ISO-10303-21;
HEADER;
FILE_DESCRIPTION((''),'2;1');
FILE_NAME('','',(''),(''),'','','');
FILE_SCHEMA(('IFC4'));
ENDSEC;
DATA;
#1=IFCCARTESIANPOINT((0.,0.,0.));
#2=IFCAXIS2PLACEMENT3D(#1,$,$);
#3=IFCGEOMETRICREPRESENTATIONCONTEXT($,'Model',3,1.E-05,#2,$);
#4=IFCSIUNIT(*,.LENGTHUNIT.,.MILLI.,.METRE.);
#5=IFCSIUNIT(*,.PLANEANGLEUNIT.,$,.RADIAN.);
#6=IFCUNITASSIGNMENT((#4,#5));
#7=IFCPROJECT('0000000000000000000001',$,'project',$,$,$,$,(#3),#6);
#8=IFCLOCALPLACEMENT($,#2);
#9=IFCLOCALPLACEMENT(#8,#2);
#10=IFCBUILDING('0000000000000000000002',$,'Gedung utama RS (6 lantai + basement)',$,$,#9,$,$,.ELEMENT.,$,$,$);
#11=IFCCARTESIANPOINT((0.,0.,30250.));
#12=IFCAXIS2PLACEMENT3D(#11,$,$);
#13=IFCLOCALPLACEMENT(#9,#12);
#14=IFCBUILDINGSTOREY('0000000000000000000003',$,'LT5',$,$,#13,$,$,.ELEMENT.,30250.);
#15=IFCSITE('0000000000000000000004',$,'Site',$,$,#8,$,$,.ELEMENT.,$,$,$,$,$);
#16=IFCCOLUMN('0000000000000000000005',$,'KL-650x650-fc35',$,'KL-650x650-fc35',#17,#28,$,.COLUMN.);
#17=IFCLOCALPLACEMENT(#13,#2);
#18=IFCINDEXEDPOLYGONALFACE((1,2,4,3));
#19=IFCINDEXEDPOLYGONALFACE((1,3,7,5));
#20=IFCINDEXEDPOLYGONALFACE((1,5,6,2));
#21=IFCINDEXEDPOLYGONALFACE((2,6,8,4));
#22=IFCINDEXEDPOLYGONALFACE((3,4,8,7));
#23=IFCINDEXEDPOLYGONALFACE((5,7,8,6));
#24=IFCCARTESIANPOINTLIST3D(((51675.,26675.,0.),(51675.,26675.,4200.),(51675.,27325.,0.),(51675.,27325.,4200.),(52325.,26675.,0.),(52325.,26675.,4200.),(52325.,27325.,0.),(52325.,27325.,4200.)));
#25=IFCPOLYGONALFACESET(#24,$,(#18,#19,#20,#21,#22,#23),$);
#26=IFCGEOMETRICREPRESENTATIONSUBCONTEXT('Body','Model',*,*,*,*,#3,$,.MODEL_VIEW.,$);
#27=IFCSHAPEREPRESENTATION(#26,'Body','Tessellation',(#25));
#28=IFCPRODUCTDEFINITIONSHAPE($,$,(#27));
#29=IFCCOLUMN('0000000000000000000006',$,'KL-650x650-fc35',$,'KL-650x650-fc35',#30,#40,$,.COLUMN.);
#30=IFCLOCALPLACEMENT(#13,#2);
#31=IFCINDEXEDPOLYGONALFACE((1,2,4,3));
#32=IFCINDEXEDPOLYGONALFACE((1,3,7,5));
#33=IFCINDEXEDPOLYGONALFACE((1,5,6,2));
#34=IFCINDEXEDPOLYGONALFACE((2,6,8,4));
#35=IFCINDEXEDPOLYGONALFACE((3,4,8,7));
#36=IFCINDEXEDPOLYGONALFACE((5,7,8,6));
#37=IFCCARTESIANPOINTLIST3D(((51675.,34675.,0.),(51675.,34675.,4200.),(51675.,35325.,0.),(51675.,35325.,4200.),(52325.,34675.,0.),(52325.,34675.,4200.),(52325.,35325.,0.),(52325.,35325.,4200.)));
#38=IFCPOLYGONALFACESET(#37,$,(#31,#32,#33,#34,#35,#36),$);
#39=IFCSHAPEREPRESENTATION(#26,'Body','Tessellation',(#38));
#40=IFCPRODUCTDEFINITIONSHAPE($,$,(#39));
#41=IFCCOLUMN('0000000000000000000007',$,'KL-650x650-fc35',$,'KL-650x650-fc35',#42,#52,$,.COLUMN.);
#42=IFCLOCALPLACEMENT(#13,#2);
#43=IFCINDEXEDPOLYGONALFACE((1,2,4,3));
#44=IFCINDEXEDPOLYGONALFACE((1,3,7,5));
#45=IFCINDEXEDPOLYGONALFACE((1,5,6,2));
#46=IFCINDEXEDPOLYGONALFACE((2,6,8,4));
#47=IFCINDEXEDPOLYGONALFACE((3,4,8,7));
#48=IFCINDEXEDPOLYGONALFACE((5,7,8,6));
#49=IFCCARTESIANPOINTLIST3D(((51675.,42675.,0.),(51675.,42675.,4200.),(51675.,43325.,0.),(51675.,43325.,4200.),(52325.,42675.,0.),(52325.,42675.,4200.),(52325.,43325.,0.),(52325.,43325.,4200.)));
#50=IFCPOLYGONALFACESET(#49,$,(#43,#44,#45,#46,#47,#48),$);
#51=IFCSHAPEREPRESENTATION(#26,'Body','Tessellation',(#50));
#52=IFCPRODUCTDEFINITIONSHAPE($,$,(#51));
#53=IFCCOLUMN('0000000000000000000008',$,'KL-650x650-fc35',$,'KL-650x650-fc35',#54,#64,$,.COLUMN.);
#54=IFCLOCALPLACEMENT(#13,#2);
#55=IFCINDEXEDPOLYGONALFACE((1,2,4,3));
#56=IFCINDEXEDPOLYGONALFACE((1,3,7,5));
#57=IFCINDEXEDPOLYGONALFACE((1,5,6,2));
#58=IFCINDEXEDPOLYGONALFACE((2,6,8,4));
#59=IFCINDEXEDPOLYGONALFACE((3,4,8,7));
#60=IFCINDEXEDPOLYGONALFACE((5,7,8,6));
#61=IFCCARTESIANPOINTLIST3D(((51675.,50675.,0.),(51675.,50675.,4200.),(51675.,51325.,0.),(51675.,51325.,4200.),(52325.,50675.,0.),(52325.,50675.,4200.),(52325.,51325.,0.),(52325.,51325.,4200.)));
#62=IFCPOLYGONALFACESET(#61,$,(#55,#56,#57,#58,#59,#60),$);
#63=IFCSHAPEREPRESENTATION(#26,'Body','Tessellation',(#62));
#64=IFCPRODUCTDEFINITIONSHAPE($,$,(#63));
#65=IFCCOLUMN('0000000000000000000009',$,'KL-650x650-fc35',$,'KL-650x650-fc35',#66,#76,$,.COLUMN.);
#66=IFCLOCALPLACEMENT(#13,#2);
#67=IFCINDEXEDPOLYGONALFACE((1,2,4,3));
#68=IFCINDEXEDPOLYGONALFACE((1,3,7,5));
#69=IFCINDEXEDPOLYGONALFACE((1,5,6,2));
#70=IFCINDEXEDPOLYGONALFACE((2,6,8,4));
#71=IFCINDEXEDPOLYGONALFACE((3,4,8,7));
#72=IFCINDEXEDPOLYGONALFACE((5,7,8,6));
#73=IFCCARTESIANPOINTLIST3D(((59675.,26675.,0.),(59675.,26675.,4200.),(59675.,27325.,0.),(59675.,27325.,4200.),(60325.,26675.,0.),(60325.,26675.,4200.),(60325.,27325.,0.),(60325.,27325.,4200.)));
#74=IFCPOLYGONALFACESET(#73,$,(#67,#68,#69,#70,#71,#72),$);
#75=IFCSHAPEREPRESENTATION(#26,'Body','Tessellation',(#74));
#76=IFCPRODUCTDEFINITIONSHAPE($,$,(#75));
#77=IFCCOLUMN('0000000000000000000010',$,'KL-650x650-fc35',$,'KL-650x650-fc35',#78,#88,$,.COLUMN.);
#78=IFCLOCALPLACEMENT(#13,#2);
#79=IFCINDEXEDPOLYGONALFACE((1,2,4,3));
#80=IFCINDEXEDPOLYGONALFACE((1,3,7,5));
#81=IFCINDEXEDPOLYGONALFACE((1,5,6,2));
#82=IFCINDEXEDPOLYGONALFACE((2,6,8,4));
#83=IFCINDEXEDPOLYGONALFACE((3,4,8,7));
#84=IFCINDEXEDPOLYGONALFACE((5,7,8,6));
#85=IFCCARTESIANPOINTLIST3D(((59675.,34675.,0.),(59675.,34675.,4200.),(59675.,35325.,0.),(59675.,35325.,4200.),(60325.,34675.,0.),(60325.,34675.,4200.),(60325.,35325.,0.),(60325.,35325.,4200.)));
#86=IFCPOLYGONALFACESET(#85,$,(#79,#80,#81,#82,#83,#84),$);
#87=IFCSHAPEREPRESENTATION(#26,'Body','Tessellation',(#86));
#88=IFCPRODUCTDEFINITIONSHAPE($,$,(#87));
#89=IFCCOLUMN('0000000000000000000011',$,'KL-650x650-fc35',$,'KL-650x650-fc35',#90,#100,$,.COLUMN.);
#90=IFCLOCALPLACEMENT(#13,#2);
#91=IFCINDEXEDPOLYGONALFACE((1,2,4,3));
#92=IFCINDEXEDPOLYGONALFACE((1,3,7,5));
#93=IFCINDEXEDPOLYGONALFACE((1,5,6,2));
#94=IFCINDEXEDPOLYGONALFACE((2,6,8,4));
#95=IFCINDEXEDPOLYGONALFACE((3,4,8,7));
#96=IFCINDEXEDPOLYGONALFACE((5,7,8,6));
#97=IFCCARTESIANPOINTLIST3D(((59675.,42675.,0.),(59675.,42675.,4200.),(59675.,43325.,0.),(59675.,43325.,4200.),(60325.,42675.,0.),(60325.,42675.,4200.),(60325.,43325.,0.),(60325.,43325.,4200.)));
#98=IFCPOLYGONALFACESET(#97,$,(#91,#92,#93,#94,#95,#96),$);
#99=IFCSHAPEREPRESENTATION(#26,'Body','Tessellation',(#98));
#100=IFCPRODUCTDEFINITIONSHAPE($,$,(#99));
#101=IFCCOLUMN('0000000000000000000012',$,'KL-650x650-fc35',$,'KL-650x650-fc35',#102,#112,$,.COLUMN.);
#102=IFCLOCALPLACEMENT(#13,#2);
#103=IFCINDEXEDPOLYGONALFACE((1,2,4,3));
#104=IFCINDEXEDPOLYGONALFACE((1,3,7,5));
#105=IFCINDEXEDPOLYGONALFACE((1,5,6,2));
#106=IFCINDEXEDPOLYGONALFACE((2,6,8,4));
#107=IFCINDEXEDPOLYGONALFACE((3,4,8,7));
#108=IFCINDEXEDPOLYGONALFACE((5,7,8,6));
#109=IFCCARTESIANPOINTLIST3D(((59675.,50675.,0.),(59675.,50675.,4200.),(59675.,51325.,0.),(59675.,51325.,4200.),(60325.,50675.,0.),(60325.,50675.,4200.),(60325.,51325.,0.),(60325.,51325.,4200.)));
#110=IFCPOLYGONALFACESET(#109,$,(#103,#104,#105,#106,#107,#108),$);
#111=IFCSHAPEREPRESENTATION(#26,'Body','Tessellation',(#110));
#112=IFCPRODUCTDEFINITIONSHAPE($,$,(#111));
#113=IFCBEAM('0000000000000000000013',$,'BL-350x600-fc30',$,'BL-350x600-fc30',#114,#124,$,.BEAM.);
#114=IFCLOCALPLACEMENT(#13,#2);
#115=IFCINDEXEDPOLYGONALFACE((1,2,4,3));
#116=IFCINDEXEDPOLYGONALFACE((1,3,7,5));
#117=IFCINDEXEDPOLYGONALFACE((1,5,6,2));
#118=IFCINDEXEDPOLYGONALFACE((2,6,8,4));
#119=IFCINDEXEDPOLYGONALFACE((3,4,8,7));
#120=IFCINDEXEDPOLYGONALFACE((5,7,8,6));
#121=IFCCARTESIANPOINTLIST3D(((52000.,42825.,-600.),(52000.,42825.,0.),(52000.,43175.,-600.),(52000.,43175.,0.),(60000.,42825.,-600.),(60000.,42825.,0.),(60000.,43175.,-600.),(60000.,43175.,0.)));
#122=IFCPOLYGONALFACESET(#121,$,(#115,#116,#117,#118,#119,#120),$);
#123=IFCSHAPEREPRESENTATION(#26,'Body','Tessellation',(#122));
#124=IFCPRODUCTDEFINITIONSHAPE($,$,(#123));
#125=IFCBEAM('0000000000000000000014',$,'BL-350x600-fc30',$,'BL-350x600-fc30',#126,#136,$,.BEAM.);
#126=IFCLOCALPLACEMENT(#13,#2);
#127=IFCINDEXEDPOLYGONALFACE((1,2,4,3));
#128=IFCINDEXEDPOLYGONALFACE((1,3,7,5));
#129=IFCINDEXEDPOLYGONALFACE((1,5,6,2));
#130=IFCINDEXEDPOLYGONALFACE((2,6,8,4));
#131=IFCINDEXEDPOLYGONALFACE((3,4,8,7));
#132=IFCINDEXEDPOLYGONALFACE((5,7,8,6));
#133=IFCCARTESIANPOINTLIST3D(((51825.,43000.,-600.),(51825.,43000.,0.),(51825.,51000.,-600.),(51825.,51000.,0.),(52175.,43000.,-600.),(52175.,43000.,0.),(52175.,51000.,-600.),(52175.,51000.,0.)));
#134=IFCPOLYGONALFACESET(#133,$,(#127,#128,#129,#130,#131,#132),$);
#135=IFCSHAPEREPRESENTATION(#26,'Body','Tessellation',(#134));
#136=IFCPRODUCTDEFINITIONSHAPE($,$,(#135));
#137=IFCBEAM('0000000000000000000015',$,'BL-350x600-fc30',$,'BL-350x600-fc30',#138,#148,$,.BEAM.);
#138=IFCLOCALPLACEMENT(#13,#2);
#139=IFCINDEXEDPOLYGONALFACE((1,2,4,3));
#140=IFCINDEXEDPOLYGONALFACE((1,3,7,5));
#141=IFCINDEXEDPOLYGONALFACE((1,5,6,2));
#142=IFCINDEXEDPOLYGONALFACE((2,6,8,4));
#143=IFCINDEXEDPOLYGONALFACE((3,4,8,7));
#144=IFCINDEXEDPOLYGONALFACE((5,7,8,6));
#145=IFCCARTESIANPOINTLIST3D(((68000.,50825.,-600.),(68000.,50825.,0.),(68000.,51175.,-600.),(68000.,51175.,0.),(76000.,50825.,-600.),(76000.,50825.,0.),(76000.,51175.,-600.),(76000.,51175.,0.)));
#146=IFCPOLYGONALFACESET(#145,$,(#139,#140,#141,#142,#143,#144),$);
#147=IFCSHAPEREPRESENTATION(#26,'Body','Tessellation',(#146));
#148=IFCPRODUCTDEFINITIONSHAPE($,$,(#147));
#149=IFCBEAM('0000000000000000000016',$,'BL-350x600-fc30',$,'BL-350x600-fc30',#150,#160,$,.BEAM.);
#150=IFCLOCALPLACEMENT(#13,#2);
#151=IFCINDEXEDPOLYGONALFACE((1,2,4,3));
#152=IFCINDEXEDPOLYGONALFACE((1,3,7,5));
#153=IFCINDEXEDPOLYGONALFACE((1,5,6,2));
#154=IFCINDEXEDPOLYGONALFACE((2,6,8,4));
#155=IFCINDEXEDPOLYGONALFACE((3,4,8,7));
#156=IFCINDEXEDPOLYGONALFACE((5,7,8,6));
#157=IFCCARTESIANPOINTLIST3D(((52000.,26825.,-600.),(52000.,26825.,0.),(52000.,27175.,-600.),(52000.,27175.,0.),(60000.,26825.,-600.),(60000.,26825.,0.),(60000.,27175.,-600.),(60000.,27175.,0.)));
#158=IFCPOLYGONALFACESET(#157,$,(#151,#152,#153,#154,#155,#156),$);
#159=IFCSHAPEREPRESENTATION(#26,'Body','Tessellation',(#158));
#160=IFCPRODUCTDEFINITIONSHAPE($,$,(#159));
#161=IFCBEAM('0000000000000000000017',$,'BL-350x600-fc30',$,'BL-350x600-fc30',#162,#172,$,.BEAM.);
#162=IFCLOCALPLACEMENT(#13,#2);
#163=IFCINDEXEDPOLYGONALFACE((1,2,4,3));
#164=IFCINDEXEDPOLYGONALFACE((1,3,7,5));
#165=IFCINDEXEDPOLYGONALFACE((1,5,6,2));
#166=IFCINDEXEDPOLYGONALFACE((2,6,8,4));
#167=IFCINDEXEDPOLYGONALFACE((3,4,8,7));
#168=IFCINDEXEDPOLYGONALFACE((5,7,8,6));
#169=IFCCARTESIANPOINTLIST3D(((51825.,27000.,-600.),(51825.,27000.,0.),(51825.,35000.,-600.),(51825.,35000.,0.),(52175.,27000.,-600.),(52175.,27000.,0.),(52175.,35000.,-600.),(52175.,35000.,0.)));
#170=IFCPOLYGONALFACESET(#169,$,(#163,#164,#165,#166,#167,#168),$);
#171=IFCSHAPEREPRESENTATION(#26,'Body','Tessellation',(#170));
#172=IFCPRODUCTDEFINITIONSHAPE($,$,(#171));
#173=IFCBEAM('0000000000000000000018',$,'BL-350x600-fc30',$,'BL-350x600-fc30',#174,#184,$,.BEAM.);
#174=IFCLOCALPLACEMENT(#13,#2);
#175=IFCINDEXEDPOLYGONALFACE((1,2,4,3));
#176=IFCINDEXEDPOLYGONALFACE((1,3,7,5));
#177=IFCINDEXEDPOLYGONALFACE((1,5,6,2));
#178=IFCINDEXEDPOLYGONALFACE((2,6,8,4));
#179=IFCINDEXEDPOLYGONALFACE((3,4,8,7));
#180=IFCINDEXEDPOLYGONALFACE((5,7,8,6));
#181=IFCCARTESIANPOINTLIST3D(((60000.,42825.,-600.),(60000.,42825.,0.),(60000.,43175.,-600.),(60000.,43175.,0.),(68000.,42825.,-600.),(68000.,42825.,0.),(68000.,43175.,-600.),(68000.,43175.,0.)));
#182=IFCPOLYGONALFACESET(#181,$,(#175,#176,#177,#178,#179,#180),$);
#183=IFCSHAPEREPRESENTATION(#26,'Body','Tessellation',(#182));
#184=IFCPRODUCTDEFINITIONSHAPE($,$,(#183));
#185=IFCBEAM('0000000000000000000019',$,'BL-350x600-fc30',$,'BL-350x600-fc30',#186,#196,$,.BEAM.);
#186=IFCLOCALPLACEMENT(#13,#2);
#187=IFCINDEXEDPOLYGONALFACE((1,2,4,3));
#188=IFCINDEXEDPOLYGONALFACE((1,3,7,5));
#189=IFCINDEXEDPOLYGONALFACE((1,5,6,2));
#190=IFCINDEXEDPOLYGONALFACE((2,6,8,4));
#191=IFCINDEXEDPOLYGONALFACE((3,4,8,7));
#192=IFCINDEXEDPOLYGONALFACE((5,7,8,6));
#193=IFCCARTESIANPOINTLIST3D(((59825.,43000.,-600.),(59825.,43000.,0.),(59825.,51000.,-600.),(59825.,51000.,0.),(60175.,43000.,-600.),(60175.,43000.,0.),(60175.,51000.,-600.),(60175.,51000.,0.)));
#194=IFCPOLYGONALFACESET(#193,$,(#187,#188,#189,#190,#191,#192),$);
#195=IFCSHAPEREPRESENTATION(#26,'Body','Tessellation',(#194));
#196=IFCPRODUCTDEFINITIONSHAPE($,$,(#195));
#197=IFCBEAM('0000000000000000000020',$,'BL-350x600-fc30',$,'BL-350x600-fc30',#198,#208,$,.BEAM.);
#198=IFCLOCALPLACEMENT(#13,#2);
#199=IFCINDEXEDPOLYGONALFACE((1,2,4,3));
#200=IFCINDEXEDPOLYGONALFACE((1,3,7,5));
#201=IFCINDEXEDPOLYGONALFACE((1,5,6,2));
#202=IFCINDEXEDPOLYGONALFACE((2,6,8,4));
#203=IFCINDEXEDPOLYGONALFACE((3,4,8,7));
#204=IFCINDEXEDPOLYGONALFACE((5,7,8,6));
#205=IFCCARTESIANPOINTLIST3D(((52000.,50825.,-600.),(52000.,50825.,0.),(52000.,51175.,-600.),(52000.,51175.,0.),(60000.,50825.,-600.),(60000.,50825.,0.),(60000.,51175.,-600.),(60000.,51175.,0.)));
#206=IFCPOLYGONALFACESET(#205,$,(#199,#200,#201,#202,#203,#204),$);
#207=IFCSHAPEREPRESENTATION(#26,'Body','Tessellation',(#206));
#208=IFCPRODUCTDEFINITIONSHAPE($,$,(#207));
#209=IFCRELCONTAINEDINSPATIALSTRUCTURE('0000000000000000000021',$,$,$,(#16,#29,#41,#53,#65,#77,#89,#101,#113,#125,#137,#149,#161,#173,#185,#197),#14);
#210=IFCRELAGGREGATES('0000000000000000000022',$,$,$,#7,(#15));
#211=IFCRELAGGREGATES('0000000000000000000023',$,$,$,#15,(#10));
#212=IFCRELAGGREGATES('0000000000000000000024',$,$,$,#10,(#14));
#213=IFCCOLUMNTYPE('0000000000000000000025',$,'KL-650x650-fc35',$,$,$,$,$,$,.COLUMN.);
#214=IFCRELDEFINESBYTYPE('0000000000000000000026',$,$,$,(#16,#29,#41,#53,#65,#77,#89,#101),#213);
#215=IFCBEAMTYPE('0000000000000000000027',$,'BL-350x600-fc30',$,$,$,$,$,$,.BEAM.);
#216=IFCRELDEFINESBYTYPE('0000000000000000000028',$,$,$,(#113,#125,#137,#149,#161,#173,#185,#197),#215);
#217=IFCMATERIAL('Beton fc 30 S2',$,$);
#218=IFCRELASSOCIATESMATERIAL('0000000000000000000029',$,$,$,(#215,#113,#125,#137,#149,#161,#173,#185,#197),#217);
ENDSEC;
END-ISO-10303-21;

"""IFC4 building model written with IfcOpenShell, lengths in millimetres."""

from ifc_helpers import new_model, si_unit, frame, origin, origin_2d, place, context, subcontext, project, spatial, rectangle, extrude, material, material_profile, profile_set, profile_usage, type_object, element, save


model = new_model("IFC4")

# Units and contexts
model_context = context("Model", 3, precision=1e-05, world=origin())
body_context = subcontext(model_context, "Body", "Model", "MODEL_VIEW")
ifc_project = project(units=[si_unit("LENGTHUNIT", "METRE", prefix="MILLI"), si_unit("PLANEANGLEUNIT", "RADIAN")], contexts=[model_context])

# Site, building, storey
site_placement = place(None, origin())
site = spatial("IfcSite", under=ifc_project, at=site_placement, Name="Site", CompositionType="ELEMENT")
building_placement = place(site_placement, origin())
building = spatial("IfcBuilding", under=site, at=building_placement, Name="Gedung utama RS (6 lantai + basement)", CompositionType="ELEMENT")
storey_placement = place(building_placement, frame((0.0, 0.0, 30250.0)))
storey = spatial("IfcBuildingStorey", under=building, at=storey_placement, Name="LT5", CompositionType="ELEMENT", Elevation=30250.0)

# Columns
ifc_material_profile_1 = material_profile(None, rectangle(XDim=650.0, YDim=650.0, at=origin_2d()), Name="KL-650x650-fc35")
ifc_profile_set_1 = profile_set([ifc_material_profile_1], Name="KL-650x650-fc35")
ifc_profile_usage_1 = profile_usage(ifc_profile_set_1, cardinal=5)
column_type = type_object("IfcColumnType", Name="KL-650x650-fc35", PredefinedType="COLUMN", material=ifc_profile_set_1)
for number, where, z_axis, x_axis, name in (
    (1, (52000.0, 27000.0, 0.0), (0.0, 0.0, 1.0), (1.0, 0.0, 0.0), "KL-650x650-fc35"),
    (2, (52000.0, 35000.0, 0.0), (0.0, 0.0, 1.0), (1.0, 0.0, 0.0), "KL-650x650-fc35"),
    (3, (52000.0, 43000.0, 0.0), (0.0, 0.0, 1.0), (1.0, 0.0, 0.0), "KL-650x650-fc35"),
    (4, (52000.0, 51000.0, 0.0), (0.0, 0.0, 1.0), (1.0, 0.0, 0.0), "KL-650x650-fc35"),
    (5, (60000.0, 27000.0, 0.0), (0.0, 0.0, 1.0), (1.0, 0.0, 0.0), "KL-650x650-fc35"),
    (6, (60000.0, 35000.0, 0.0), (0.0, 0.0, 1.0), (1.0, 0.0, 0.0), "KL-650x650-fc35"),
    (7, (60000.0, 43000.0, 0.0), (0.0, 0.0, 1.0), (1.0, 0.0, 0.0), "KL-650x650-fc35"),
    (8, (60000.0, 51000.0, 0.0), (0.0, 0.0, 1.0), (1.0, 0.0, 0.0), "KL-650x650-fc35"),
):
    element("IfcColumn", number, at=place(storey_placement, frame(where, z_axis=z_axis, x_axis=x_axis)), inside=storey, type_object=column_type, material=ifc_profile_usage_1, Name=name, ObjectType="KL-650x650-fc35", PredefinedType="COLUMN", context=body_context, shape_type="SweptSolid", body=[
        extrude(rectangle(XDim=650.0, YDim=650.0, at=origin_2d()), origin(), (0.0, 0.0, 1.0), 4200.0),
    ])

# Beams
ifc_material_1 = material(Name="Beton fc 30 S2")
ifc_material_profile_2 = material_profile(ifc_material_1, rectangle(XDim=350.0, YDim=600.0, at=origin_2d()), Name="BL-350x600-fc30")
ifc_profile_set_2 = profile_set([ifc_material_profile_2], Name="BL-350x600-fc30")
ifc_profile_usage_2 = profile_usage(ifc_profile_set_2, cardinal=8)
beam_type = type_object("IfcBeamType", Name="BL-350x600-fc30", PredefinedType="BEAM", material=ifc_profile_set_2)
beam_1_placement = place(storey_placement, frame((52000.0, 43000.0, -300.0)))
element("IfcBeam", 9, at=beam_1_placement, inside=storey, type_object=beam_type, material=ifc_profile_usage_2, Name="BL-350x600-fc30", ObjectType="BL-350x600-fc30", PredefinedType="BEAM", context=body_context, shape_type="SweptSolid", body=[
    extrude(rectangle(XDim=350.0, YDim=600.0, at=origin_2d()), frame((0.0, 0.0, 0.0), z_axis=(1.0, 0.0, 0.0), x_axis=(0.0, 1.0, 0.0)), (0.0, 0.0, 1.0), 8000.0),
])
beam_2_placement = place(storey_placement, frame((52000.0, 43000.0, -300.0)))
element("IfcBeam", 10, at=beam_2_placement, inside=storey, type_object=beam_type, material=ifc_profile_usage_2, Name="BL-350x600-fc30", ObjectType="BL-350x600-fc30", PredefinedType="BEAM", context=body_context, shape_type="SweptSolid", body=[
    extrude(rectangle(XDim=350.0, YDim=600.0, at=origin_2d()), frame((0.0, 0.0, 0.0), z_axis=(0.0, 1.0, 0.0), x_axis=(-1.0, 0.0, 0.0)), (0.0, 0.0, 1.0), 8000.0),
])
for number, where, name in (
    (11, (68000.0, 51000.0, -300.0), "BL-350x600-fc30"),
    (12, (52000.0, 27000.0, -300.0), "BL-350x600-fc30"),
):
    element("IfcBeam", number, at=place(storey_placement, frame(where)), inside=storey, type_object=beam_type, material=ifc_profile_usage_2, Name=name, ObjectType="BL-350x600-fc30", PredefinedType="BEAM", context=body_context, shape_type="SweptSolid", body=[
        extrude(rectangle(XDim=350.0, YDim=600.0, at=origin_2d()), frame((0.0, 0.0, 0.0), z_axis=(1.0, 0.0, 0.0), x_axis=(0.0, 1.0, 0.0)), (0.0, 0.0, 1.0), 8000.0),
    ])
beam_3_placement = place(storey_placement, frame((52000.0, 27000.0, -300.0)))
element("IfcBeam", 13, at=beam_3_placement, inside=storey, type_object=beam_type, material=ifc_profile_usage_2, Name="BL-350x600-fc30", ObjectType="BL-350x600-fc30", PredefinedType="BEAM", context=body_context, shape_type="SweptSolid", body=[
    extrude(rectangle(XDim=350.0, YDim=600.0, at=origin_2d()), frame((0.0, 0.0, 0.0), z_axis=(0.0, 1.0, 0.0), x_axis=(-1.0, 0.0, 0.0)), (0.0, 0.0, 1.0), 8000.0),
])
beam_4_placement = place(storey_placement, frame((60000.0, 43000.0, -300.0)))
element("IfcBeam", 14, at=beam_4_placement, inside=storey, type_object=beam_type, material=ifc_profile_usage_2, Name="BL-350x600-fc30", ObjectType="BL-350x600-fc30", PredefinedType="BEAM", context=body_context, shape_type="SweptSolid", body=[
    extrude(rectangle(XDim=350.0, YDim=600.0, at=origin_2d()), frame((0.0, 0.0, 0.0), z_axis=(1.0, 0.0, 0.0), x_axis=(0.0, 1.0, 0.0)), (0.0, 0.0, 1.0), 8000.0),
])
beam_5_placement = place(storey_placement, frame((60000.0, 43000.0, -300.0)))
element("IfcBeam", 15, at=beam_5_placement, inside=storey, type_object=beam_type, material=ifc_profile_usage_2, Name="BL-350x600-fc30", ObjectType="BL-350x600-fc30", PredefinedType="BEAM", context=body_context, shape_type="SweptSolid", body=[
    extrude(rectangle(XDim=350.0, YDim=600.0, at=origin_2d()), frame((0.0, 0.0, 0.0), z_axis=(0.0, 1.0, 0.0), x_axis=(-1.0, 0.0, 0.0)), (0.0, 0.0, 1.0), 8000.0),
])
for number, where, name in (
    (16, (52000.0, 51000.0, -300.0), "BL-350x600-fc30"),
):
    element("IfcBeam", number, at=place(storey_placement, frame(where)), inside=storey, type_object=beam_type, material=ifc_profile_usage_2, Name=name, ObjectType="BL-350x600-fc30", PredefinedType="BEAM", context=body_context, shape_type="SweptSolid", body=[
        extrude(rectangle(XDim=350.0, YDim=600.0, at=origin_2d()), frame((0.0, 0.0, 0.0), z_axis=(1.0, 0.0, 0.0), x_axis=(0.0, 1.0, 0.0)), (0.0, 0.0, 1.0), 8000.0),
    ])

save(model, "model.ifc")
